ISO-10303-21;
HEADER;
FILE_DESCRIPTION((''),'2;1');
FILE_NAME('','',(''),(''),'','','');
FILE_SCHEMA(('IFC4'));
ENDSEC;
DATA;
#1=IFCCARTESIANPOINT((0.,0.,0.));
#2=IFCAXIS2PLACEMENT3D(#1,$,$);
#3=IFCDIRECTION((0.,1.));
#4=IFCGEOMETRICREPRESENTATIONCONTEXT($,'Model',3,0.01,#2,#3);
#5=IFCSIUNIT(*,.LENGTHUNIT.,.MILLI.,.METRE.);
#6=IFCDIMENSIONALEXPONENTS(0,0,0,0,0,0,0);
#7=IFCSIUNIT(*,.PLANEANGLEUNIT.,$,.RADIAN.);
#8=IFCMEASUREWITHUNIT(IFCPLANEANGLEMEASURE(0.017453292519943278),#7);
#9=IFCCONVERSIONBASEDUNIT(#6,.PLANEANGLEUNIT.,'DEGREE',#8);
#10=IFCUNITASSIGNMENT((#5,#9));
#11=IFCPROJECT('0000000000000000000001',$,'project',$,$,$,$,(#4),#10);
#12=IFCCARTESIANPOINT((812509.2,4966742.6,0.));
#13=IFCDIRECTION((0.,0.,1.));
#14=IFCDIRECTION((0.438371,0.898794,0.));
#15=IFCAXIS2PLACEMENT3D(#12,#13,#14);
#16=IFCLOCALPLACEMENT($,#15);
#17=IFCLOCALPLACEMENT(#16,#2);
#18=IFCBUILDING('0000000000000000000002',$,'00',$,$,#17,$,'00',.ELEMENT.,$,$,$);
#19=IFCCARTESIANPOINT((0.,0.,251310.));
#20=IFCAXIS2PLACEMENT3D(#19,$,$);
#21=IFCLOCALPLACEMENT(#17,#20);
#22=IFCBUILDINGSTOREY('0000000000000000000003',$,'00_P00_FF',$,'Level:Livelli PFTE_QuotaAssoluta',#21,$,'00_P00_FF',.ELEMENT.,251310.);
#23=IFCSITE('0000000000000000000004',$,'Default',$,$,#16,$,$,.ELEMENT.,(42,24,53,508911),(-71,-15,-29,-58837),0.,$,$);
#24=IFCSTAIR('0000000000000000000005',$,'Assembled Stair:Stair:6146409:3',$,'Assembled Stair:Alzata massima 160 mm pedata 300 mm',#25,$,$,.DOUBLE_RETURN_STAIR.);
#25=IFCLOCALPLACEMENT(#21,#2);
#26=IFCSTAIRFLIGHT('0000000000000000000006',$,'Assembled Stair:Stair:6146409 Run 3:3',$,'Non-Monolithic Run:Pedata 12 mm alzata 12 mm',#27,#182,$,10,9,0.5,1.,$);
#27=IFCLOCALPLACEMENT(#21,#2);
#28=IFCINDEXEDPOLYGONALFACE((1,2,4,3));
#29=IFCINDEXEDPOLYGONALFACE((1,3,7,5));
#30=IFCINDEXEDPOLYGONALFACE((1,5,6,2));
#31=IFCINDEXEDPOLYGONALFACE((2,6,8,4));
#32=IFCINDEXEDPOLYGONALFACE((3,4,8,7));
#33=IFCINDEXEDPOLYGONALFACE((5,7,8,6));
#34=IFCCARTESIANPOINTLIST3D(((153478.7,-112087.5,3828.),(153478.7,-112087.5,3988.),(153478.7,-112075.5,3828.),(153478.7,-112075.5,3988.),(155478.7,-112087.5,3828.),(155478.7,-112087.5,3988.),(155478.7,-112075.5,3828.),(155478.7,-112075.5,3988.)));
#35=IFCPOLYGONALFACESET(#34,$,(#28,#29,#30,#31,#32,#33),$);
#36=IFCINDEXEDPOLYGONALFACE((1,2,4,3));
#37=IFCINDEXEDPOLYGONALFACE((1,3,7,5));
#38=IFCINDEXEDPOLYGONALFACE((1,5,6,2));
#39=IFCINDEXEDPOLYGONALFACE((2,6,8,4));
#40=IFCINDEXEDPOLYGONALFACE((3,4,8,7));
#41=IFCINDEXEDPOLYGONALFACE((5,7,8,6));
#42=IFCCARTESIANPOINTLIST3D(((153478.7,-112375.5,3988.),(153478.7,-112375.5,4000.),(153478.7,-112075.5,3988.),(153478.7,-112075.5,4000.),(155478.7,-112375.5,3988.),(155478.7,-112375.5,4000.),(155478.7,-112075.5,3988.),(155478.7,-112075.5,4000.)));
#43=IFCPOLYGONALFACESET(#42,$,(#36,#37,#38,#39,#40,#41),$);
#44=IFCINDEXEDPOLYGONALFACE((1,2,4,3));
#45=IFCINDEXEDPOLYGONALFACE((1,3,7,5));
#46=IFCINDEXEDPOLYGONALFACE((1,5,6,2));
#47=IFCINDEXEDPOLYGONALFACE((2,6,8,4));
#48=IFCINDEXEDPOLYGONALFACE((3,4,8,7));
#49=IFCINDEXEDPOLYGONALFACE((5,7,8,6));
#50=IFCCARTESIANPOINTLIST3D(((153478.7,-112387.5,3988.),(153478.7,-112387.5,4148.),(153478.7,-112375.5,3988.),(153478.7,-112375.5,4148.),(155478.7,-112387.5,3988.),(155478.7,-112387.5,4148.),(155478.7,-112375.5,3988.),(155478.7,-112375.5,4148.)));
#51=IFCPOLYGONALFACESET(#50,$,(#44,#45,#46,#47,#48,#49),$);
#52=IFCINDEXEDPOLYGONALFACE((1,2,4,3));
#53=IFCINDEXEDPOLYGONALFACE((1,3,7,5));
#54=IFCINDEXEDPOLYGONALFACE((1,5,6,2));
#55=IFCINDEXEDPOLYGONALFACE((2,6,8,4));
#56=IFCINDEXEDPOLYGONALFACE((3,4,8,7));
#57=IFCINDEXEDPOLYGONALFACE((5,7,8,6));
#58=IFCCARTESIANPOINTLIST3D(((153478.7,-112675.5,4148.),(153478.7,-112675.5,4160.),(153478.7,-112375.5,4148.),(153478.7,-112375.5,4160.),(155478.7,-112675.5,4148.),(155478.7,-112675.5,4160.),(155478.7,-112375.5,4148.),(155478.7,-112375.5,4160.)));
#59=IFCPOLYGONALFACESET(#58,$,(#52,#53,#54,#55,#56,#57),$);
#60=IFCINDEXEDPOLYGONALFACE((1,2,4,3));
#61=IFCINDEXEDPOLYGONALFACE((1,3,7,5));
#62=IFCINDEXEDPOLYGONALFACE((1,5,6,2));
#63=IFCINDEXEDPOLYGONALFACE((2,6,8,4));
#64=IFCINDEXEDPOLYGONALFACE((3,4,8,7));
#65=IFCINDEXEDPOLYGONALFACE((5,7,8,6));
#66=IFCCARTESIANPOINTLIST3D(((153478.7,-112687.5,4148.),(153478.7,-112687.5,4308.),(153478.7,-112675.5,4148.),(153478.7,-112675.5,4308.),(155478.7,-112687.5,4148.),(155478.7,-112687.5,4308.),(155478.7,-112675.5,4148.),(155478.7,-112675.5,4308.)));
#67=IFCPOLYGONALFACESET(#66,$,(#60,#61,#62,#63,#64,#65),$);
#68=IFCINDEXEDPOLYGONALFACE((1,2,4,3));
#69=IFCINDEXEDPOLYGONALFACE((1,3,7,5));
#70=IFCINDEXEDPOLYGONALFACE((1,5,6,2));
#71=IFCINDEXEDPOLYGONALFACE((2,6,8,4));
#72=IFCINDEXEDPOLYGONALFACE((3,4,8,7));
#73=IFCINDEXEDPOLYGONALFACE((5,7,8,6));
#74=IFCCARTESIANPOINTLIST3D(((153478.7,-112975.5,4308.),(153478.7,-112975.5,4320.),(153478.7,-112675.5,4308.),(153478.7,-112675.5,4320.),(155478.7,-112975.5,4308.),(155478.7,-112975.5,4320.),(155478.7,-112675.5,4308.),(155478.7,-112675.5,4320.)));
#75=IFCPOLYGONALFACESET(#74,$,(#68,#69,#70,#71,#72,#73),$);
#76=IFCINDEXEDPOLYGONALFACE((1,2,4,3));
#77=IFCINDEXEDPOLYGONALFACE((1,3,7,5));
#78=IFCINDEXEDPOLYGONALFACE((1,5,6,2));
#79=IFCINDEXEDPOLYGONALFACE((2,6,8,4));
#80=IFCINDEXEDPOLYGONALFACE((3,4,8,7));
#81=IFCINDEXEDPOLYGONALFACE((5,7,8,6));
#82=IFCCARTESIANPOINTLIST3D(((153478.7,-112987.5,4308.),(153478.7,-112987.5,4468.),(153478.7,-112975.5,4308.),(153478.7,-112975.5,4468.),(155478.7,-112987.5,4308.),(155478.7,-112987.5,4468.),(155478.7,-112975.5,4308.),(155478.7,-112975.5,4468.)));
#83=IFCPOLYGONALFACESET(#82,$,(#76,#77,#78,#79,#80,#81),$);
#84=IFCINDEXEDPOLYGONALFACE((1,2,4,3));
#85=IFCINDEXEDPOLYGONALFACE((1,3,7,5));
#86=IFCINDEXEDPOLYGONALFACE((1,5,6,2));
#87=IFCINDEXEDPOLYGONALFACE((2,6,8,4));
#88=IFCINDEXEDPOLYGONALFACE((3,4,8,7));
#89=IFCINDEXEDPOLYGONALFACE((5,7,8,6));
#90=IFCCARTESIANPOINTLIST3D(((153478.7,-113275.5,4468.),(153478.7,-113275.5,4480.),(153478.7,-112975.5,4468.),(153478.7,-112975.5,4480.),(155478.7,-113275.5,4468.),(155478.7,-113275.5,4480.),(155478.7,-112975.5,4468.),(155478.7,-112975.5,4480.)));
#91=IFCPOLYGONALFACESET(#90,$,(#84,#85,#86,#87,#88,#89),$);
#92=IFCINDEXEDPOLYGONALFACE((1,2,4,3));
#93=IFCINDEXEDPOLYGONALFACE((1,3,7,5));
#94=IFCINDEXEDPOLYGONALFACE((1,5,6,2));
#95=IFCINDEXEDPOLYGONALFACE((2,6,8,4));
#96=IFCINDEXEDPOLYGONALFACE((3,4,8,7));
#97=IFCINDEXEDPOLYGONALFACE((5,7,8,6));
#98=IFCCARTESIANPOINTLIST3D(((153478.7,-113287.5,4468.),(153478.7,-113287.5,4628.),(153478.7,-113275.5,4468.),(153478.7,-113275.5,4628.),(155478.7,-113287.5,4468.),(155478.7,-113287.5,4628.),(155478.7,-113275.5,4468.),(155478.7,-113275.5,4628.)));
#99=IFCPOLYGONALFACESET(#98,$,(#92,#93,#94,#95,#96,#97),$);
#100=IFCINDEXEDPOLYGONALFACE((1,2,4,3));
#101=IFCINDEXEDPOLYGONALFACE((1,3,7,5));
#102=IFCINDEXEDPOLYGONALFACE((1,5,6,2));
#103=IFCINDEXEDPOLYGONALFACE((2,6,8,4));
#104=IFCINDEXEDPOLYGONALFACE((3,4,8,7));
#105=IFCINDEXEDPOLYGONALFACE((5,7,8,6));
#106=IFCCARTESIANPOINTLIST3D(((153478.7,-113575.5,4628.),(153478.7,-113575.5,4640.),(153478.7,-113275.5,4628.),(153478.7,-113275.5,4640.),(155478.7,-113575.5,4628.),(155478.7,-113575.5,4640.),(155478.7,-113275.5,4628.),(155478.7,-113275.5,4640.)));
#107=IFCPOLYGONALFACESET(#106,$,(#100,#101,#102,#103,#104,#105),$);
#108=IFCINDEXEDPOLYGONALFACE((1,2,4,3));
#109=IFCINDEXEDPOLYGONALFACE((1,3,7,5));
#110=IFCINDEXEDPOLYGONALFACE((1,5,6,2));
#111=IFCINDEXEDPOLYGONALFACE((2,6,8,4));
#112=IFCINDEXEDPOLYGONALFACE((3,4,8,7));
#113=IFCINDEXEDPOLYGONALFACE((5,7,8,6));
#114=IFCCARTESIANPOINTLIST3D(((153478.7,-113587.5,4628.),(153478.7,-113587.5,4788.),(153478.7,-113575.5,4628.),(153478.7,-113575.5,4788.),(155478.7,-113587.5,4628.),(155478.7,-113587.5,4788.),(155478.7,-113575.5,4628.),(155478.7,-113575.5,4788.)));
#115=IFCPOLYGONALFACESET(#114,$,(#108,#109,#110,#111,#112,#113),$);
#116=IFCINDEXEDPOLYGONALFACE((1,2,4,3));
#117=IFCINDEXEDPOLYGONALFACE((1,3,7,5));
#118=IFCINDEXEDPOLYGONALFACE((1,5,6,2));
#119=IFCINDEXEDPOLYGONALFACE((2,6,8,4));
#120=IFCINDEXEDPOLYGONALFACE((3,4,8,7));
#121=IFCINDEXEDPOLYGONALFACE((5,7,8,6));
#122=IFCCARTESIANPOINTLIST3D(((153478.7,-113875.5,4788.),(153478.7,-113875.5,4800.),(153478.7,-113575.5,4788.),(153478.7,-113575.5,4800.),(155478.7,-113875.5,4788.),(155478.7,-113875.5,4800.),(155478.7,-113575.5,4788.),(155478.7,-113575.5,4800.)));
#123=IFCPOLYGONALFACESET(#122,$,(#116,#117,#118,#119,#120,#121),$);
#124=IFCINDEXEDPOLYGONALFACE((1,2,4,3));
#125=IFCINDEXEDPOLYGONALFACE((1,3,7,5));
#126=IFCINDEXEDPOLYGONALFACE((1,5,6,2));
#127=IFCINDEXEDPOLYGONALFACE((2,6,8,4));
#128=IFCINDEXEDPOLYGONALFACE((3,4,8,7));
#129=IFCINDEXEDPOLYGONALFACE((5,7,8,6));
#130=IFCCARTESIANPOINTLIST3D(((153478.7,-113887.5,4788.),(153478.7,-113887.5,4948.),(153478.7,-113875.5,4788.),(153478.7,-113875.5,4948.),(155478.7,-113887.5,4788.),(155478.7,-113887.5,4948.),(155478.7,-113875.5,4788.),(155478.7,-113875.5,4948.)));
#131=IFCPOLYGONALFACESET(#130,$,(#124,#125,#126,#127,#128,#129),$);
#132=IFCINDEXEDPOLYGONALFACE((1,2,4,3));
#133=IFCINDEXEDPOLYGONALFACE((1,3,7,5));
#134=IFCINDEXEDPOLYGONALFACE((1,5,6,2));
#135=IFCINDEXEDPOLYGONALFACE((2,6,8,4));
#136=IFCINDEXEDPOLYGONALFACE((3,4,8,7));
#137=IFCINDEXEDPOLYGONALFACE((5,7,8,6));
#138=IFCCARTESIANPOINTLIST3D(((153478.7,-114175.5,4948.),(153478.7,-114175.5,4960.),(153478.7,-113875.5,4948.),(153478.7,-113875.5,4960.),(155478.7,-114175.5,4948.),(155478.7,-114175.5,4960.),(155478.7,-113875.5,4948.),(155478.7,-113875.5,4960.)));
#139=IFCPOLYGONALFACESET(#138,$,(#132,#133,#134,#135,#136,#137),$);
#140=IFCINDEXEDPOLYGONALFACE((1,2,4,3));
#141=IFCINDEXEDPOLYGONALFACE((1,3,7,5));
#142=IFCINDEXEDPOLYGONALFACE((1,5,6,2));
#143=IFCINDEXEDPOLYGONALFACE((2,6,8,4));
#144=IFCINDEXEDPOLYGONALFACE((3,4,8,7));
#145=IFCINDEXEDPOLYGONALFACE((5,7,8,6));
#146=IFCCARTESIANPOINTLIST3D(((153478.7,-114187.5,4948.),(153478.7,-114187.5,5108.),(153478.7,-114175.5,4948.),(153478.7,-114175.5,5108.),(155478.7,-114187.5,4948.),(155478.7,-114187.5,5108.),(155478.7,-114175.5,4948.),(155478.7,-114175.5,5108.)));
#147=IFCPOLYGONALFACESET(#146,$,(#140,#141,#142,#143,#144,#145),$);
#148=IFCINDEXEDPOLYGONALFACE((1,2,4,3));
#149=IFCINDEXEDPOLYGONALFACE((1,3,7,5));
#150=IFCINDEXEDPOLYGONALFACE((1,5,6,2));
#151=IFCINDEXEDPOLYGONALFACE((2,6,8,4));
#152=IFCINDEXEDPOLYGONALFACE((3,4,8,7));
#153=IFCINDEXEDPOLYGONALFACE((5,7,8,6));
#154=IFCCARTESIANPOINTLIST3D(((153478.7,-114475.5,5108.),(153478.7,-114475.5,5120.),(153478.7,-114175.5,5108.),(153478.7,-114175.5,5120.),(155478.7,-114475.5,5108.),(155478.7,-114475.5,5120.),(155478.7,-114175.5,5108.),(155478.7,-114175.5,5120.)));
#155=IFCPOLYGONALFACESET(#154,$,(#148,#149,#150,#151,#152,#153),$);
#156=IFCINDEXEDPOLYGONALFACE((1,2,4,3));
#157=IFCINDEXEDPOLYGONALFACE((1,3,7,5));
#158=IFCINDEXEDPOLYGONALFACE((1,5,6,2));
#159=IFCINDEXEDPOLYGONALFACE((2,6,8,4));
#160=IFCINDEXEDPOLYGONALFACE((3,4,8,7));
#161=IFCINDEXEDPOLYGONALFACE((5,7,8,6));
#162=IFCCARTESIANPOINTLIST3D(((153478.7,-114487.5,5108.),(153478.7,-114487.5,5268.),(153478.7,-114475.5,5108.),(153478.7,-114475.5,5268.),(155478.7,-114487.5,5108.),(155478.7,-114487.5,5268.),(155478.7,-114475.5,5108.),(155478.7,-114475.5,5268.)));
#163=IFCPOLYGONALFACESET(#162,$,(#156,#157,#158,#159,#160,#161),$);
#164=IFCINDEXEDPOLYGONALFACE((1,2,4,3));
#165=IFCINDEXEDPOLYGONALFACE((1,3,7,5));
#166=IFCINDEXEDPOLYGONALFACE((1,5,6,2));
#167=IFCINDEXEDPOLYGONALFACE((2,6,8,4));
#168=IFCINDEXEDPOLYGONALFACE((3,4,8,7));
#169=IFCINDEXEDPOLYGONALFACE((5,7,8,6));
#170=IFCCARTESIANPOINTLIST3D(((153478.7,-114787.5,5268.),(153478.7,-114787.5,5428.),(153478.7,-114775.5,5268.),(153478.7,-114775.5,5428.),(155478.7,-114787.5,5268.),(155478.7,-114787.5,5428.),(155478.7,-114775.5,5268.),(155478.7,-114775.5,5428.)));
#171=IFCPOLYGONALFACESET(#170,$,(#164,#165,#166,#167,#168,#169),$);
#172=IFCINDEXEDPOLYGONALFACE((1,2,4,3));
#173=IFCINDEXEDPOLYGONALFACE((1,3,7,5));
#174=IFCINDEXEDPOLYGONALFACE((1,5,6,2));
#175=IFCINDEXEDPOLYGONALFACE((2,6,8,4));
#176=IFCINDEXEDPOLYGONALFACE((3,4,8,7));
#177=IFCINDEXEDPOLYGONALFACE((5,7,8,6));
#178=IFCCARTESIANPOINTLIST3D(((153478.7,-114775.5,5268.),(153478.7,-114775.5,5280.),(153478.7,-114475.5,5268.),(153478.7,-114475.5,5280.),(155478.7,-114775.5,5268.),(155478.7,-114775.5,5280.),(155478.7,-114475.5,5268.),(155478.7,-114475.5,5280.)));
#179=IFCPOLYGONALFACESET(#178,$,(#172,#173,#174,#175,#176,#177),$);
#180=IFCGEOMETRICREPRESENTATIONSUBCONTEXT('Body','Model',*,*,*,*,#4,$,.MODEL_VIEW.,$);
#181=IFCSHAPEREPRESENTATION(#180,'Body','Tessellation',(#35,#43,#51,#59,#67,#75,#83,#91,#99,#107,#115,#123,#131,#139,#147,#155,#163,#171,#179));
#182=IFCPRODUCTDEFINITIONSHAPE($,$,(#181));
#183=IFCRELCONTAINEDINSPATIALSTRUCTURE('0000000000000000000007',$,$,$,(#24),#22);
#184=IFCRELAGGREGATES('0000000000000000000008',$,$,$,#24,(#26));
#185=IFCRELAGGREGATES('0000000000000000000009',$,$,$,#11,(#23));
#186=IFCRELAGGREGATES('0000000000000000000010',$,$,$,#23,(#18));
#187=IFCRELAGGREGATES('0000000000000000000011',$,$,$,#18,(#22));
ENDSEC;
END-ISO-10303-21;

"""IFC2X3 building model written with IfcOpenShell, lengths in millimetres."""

from ifc_helpers import new_model, entity, si_unit, converted_unit, direction, frame, frame_2d, origin, origin_2d_with_axis, place, context, subcontext, project, spatial, rectangle, extrude, element, aggregate, save


model = new_model("IFC2X3")

# Units and contexts
model_context = context("Model", 3, precision=0.01, world=origin(), true_north=direction((0.0, 1.0)))
body_context = subcontext(model_context, "Body", "Model", "MODEL_VIEW")
ifc_project = project(units=[si_unit("LENGTHUNIT", "METRE", prefix="MILLI"), converted_unit("PLANEANGLEUNIT", "DEGREE", entity("IfcPlaneAngleMeasure", 0.017453292519943278), si_unit("PLANEANGLEUNIT", "RADIAN"), dimensions=[0, 0, 0, 0, 0, 0, 0])], contexts=[model_context])

# Site, building, storey
site_placement = place(None, frame((812509.2, 4966742.6, 0.0), z_axis=(0.0, 0.0, 1.0), x_axis=(0.438371, 0.898794, 0.0)))
site = spatial("IfcSite", under=ifc_project, at=site_placement, Name="Default", CompositionType="ELEMENT", RefLatitude=(42, 24, 53, 508911), RefLongitude=(-71, -15, -29, -58837), RefElevation=0.0)
building_placement = place(site_placement, origin())
building = spatial("IfcBuilding", under=site, at=building_placement, Name="00", LongName="00", CompositionType="ELEMENT")
storey_placement = place(building_placement, frame((0.0, 0.0, 251310.0)))
storey = spatial("IfcBuildingStorey", under=building, at=storey_placement, Name="00_P00_FF", ObjectType="Level:Livelli PFTE_QuotaAssoluta", LongName="00_P00_FF", CompositionType="ELEMENT", Elevation=251310.0)

# Stair
stair_1_placement = place(storey_placement, origin())
stair_1 = element("IfcStair", 1, at=stair_1_placement, inside=storey, Name="Assembled Stair:Stair:6146409:3", ObjectType="Assembled Stair:Alzata massima 160 mm pedata 300 mm", ShapeType="DOUBLE_RETURN_STAIR")

# Stair flight
stair_flight_1_placement = place(stair_1_placement, origin())
stair_flight_1 = element("IfcStairFlight", 2, at=stair_flight_1_placement, Name="Assembled Stair:Stair:6146409 Run 3:3", ObjectType="Non-Monolithic Run:Pedata 12 mm alzata 12 mm", NumberOfRiser=10, NumberOfTreads=9, RiserHeight=0.5, TreadLength=1.0, context=body_context, shape_type="SweptSolid", body=[
    extrude(rectangle(XDim=2000.0, YDim=12.0, at=origin_2d_with_axis()), frame((154478.7, -112081.5, 3828.0)), (0.0, 0.0, 1.0), 160.0),
    extrude(rectangle(XDim=300.0, YDim=2000.0, at=origin_2d_with_axis()), frame((154478.7, -112225.5, 3988.0), z_axis=(0.0, 0.0, 1.0), x_axis=(0.0, 1.0, 0.0)), (0.0, 0.0, 1.0), 12.0),
    extrude(rectangle(XDim=2000.0, YDim=12.0, at=origin_2d_with_axis()), frame((154478.7, -112381.5, 3988.0)), (0.0, 0.0, 1.0), 160.0),
    extrude(rectangle(XDim=300.0, YDim=2000.0, at=frame_2d((0.0, 0.0), x_axis=(1.0, 0.0))), frame((154478.7, -112525.5, 4148.0), z_axis=(0.0, 0.0, 1.0), x_axis=(0.0, 1.0, 0.0)), (0.0, 0.0, 1.0), 12.0),
    extrude(rectangle(XDim=2000.0, YDim=12.0, at=frame_2d((0.0, 0.0), x_axis=(1.0, 0.0))), frame((154478.7, -112681.5, 4148.0)), (0.0, 0.0, 1.0), 160.0),
    extrude(rectangle(XDim=300.0, YDim=2000.0, at=frame_2d((0.0, 0.0), x_axis=(1.0, 0.0))), frame((154478.7, -112825.5, 4308.0), z_axis=(0.0, 0.0, 1.0), x_axis=(0.0, 1.0, 0.0)), (0.0, 0.0, 1.0), 12.0),
    extrude(rectangle(XDim=2000.0, YDim=12.0, at=frame_2d((0.0, 0.0), x_axis=(1.0, 0.0))), frame((154478.7, -112981.5, 4308.0)), (0.0, 0.0, 1.0), 160.0),
    extrude(rectangle(XDim=300.0, YDim=2000.0, at=frame_2d((0.0, 0.0), x_axis=(1.0, 0.0))), frame((154478.7, -113125.5, 4468.0), z_axis=(0.0, 0.0, 1.0), x_axis=(0.0, 1.0, 0.0)), (0.0, 0.0, 1.0), 12.0),
    extrude(rectangle(XDim=2000.0, YDim=12.0, at=frame_2d((0.0, 0.0), x_axis=(1.0, 0.0))), frame((154478.7, -113281.5, 4468.0)), (0.0, 0.0, 1.0), 160.0),
    extrude(rectangle(XDim=300.0, YDim=2000.0, at=frame_2d((0.0, 0.0), x_axis=(1.0, 0.0))), frame((154478.7, -113425.5, 4628.0), z_axis=(0.0, 0.0, 1.0), x_axis=(0.0, 1.0, 0.0)), (0.0, 0.0, 1.0), 12.0),
    extrude(rectangle(XDim=2000.0, YDim=12.0, at=frame_2d((0.0, 0.0), x_axis=(1.0, 0.0))), frame((154478.7, -113581.5, 4628.0)), (0.0, 0.0, 1.0), 160.0),
    extrude(rectangle(XDim=300.0, YDim=2000.0, at=frame_2d((0.0, 0.0), x_axis=(1.0, 0.0))), frame((154478.7, -113725.5, 4788.0), z_axis=(0.0, 0.0, 1.0), x_axis=(0.0, 1.0, 0.0)), (0.0, 0.0, 1.0), 12.0),
    extrude(rectangle(XDim=2000.0, YDim=12.0, at=origin_2d_with_axis()), frame((154478.7, -113881.5, 4788.0)), (0.0, 0.0, 1.0), 160.0),
    extrude(rectangle(XDim=300.0, YDim=2000.0, at=frame_2d((0.0, 0.0), x_axis=(1.0, 0.0))), frame((154478.7, -114025.5, 4948.0), z_axis=(0.0, 0.0, 1.0), x_axis=(0.0, 1.0, 0.0)), (0.0, 0.0, 1.0), 12.0),
    extrude(rectangle(XDim=2000.0, YDim=12.0, at=origin_2d_with_axis()), frame((154478.7, -114181.5, 4948.0)), (0.0, 0.0, 1.0), 160.0),
    extrude(rectangle(XDim=300.0, YDim=2000.0, at=frame_2d((0.0, 0.0), x_axis=(1.0, 0.0))), frame((154478.7, -114325.5, 5108.0), z_axis=(0.0, 0.0, 1.0), x_axis=(0.0, 1.0, 0.0)), (0.0, 0.0, 1.0), 12.0),
    extrude(rectangle(XDim=2000.0, YDim=12.0, at=origin_2d_with_axis()), frame((154478.7, -114481.5, 5108.0)), (0.0, 0.0, 1.0), 160.0),
    extrude(rectangle(XDim=2000.0, YDim=12.0, at=origin_2d_with_axis()), frame((154478.7, -114781.5, 5268.0)), (0.0, 0.0, 1.0), 160.0),
    extrude(rectangle(XDim=300.0, YDim=2000.0, at=frame_2d((0.0, 0.0), x_axis=(1.0, 0.0))), frame((154478.7, -114625.5, 5268.0), z_axis=(0.0, 0.0, 1.0), x_axis=(0.0, 1.0, 0.0)), (0.0, 0.0, 1.0), 12.0),
])
aggregate(stair_1, [stair_flight_1])

save(model, "model.ifc")
